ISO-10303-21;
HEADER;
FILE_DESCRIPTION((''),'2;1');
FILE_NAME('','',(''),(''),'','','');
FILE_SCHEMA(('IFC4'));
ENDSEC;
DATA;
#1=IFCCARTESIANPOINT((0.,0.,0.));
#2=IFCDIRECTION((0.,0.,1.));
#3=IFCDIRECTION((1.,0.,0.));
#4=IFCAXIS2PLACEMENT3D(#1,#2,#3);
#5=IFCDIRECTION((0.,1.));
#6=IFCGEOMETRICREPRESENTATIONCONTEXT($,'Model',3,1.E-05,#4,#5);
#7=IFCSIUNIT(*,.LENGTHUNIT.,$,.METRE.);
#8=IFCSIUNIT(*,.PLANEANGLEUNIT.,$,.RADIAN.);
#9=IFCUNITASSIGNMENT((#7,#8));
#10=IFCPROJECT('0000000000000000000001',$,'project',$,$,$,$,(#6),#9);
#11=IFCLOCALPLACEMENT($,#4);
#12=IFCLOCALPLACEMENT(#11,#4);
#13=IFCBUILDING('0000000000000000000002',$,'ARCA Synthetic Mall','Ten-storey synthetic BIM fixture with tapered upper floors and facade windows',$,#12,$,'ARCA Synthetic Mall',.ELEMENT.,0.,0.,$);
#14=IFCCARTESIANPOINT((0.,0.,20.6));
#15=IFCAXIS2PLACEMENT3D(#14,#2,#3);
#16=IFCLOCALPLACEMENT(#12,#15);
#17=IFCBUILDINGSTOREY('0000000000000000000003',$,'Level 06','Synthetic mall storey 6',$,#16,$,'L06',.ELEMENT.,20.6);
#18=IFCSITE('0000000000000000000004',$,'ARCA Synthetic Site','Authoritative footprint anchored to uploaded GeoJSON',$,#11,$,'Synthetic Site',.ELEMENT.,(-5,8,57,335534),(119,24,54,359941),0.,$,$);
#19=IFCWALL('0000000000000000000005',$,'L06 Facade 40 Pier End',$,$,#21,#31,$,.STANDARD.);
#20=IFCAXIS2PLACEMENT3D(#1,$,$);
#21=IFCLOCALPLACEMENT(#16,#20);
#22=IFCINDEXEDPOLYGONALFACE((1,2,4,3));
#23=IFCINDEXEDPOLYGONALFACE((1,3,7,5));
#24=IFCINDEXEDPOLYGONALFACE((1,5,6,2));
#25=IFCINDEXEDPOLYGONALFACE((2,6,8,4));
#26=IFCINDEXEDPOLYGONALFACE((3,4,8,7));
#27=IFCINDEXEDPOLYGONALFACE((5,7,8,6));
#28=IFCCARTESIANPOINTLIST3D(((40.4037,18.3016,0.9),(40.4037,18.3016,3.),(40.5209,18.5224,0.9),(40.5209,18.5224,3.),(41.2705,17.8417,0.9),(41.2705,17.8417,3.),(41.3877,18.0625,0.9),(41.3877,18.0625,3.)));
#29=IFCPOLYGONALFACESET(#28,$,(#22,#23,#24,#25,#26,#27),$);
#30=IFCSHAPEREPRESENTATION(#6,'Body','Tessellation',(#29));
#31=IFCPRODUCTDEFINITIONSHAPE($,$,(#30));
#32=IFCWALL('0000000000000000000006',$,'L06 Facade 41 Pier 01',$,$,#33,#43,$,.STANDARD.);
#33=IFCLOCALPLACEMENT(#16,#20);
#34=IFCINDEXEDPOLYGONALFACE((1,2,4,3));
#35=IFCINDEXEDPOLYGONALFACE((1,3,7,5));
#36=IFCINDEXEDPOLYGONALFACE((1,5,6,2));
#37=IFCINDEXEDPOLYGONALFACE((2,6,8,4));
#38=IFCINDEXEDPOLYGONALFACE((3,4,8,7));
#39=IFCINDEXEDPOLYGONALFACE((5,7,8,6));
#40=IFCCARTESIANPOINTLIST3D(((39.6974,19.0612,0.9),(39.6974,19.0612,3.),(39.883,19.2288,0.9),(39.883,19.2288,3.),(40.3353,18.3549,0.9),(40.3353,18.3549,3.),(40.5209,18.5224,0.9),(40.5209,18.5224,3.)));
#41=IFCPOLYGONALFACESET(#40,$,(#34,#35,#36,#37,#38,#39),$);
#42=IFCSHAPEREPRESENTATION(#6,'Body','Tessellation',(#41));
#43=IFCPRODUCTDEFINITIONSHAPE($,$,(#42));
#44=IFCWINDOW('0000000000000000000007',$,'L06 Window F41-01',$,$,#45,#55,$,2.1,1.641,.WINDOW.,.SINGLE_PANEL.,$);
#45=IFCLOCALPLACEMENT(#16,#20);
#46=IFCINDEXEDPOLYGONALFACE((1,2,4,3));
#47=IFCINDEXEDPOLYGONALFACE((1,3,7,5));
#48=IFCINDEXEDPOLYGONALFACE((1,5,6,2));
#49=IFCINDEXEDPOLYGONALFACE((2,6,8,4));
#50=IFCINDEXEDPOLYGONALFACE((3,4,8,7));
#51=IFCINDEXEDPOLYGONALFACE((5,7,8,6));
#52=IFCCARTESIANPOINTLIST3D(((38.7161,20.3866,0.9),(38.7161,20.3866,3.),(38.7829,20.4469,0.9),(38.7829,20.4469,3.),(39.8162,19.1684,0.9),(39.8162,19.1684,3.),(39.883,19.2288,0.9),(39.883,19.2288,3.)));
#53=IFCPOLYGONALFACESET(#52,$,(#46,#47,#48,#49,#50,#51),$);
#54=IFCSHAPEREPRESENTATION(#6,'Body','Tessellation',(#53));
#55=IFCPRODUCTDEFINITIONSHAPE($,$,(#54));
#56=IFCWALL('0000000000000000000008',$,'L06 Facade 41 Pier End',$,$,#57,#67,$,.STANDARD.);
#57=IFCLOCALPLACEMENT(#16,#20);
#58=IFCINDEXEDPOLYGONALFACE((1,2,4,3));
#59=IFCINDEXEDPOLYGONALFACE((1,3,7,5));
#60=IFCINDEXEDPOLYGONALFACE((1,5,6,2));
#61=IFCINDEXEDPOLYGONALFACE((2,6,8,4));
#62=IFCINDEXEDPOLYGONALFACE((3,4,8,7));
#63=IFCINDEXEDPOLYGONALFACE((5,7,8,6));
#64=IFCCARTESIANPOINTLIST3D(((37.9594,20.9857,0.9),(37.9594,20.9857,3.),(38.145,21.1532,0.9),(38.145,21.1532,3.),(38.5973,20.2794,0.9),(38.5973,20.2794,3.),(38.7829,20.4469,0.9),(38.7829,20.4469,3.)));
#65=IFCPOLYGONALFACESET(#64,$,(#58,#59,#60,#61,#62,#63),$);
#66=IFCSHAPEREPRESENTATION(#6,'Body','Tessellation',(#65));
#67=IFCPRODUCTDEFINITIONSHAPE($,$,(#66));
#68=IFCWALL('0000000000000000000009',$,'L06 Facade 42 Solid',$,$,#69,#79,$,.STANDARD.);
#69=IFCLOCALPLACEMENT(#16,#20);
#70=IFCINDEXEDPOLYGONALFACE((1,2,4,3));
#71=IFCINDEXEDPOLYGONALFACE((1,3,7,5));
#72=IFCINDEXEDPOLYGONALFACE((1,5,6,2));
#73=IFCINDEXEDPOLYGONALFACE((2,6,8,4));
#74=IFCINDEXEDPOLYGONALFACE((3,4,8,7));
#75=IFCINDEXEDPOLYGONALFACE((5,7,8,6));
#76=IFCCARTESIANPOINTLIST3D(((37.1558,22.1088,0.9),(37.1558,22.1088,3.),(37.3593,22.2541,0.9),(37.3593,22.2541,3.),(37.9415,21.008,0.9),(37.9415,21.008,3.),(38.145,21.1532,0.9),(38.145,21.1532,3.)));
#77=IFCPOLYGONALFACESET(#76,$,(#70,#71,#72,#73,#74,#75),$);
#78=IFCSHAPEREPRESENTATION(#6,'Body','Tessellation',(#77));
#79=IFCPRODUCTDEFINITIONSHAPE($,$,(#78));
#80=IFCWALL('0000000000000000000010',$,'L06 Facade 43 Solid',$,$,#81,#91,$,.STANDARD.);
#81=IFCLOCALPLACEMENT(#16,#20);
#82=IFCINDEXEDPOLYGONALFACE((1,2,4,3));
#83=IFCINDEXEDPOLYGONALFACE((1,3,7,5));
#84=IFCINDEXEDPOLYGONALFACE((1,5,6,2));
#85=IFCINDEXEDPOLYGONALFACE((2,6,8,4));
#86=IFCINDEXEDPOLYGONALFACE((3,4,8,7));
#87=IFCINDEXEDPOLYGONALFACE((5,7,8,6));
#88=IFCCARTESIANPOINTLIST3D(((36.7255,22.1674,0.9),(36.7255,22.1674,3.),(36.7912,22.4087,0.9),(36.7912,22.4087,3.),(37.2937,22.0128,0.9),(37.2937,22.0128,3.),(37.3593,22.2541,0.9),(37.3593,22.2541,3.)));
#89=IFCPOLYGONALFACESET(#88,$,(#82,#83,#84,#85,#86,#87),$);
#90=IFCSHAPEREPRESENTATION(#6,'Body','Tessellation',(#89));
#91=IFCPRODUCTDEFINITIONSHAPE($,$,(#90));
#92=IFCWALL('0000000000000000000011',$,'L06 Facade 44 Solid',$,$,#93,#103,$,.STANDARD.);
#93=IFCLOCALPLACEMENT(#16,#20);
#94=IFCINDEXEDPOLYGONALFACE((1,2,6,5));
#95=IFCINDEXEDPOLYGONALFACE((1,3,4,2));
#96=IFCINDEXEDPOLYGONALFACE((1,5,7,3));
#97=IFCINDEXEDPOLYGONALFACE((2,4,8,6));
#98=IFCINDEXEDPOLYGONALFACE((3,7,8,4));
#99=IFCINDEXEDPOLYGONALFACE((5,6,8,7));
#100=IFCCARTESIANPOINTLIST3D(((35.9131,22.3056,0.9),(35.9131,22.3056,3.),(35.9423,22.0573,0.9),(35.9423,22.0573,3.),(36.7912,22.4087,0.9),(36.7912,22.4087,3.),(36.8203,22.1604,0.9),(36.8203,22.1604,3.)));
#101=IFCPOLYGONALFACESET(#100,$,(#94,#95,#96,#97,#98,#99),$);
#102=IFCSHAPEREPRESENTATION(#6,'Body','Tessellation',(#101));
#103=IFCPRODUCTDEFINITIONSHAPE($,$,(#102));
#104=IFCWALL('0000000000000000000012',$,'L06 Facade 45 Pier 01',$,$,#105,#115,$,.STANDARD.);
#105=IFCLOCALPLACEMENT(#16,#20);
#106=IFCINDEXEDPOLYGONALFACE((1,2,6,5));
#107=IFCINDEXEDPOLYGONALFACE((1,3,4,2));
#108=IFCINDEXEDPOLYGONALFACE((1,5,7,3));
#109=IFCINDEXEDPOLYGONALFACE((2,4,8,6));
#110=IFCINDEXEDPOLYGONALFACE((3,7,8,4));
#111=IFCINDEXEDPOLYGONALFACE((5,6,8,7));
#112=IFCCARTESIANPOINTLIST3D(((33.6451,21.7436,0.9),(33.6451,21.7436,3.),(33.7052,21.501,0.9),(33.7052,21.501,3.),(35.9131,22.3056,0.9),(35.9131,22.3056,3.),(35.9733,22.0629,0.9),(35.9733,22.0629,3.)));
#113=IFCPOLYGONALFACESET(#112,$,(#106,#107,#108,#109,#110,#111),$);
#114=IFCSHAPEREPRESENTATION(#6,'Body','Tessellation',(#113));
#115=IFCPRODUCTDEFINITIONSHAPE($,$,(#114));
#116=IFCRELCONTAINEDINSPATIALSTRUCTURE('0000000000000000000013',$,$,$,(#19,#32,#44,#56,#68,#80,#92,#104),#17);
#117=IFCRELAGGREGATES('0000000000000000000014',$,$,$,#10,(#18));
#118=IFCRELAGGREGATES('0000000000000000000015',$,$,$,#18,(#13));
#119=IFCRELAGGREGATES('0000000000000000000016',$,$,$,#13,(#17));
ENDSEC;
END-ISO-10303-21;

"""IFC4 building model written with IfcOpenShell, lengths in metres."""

from ifc_helpers import new_model, si_unit, direction, frame, origin_with_axes, place, context, project, spatial, polyline, outline, extrude, element, save


model = new_model("IFC4")

# Units and contexts
model_context = context("Model", 3, precision=1e-05, world=origin_with_axes(), true_north=direction((0.0, 1.0)))
ifc_project = project(units=[si_unit("LENGTHUNIT", "METRE"), si_unit("PLANEANGLEUNIT", "RADIAN")], contexts=[model_context])

# Site, building, storey
site_placement = place(None, origin_with_axes())
site = spatial("IfcSite", under=ifc_project, at=site_placement, Name="ARCA Synthetic Site", Description="Authoritative footprint anchored to uploaded GeoJSON", LongName="Synthetic Site", CompositionType="ELEMENT", RefLatitude=(-5, 8, 57, 335534), RefLongitude=(119, 24, 54, 359941), RefElevation=0.0)
building_placement = place(site_placement, origin_with_axes())
building = spatial("IfcBuilding", under=site, at=building_placement, Name="ARCA Synthetic Mall", Description="Ten-storey synthetic BIM fixture with tapered upper floors and facade windows", LongName="ARCA Synthetic Mall", CompositionType="ELEMENT", ElevationOfRefHeight=0.0, ElevationOfTerrain=0.0)
storey_placement = place(building_placement, frame((0.0, 0.0, 20.6), z_axis=(0.0, 0.0, 1.0), x_axis=(1.0, 0.0, 0.0)))
storey = spatial("IfcBuildingStorey", under=building, at=storey_placement, Name="Level 06", Description="Synthetic mall storey 6", LongName="L06", CompositionType="ELEMENT", Elevation=20.6)

# Walls
wall_1_placement = place(storey_placement, frame((0.0, 0.0, 0.9), z_axis=(0.0, 0.0, 1.0), x_axis=(1.0, 0.0, 0.0)))
element("IfcWall", 1, at=wall_1_placement, inside=storey, Name="L06 Facade 40 Pier End", PredefinedType="STANDARD", context=model_context, shape_type="SweptSolid", body=[
    extrude(outline(polyline([(41.3877, 18.0625), (40.5209, 18.5224), (40.4037, 18.3016), (41.2705, 17.8417), (41.3877, 18.0625)])), origin_with_axes(), (0.0, 0.0, 1.0), 2.1),
])
wall_2_placement = place(storey_placement, frame((0.0, 0.0, 0.9), z_axis=(0.0, 0.0, 1.0), x_axis=(1.0, 0.0, 0.0)))
element("IfcWall", 2, at=wall_2_placement, inside=storey, Name="L06 Facade 41 Pier 01", PredefinedType="STANDARD", context=model_context, shape_type="SweptSolid", body=[
    extrude(outline(polyline([(40.5209, 18.5224), (39.883, 19.2288), (39.6974, 19.0612), (40.3353, 18.3549), (40.5209, 18.5224)])), origin_with_axes(), (0.0, 0.0, 1.0), 2.1),
])

# Window
window_1_placement = place(storey_placement, frame((0.0, 0.0, 0.9), z_axis=(0.0, 0.0, 1.0), x_axis=(1.0, 0.0, 0.0)))
element("IfcWindow", 3, at=window_1_placement, inside=storey, Name="L06 Window F41-01", OverallHeight=2.1, OverallWidth=1.641, PartitioningType="SINGLE_PANEL", PredefinedType="WINDOW", context=model_context, shape_type="SweptSolid", body=[
    extrude(outline(polyline([(39.883, 19.2288), (38.7829, 20.4469), (38.7161, 20.3866), (39.8162, 19.1684), (39.883, 19.2288)])), origin_with_axes(), (0.0, 0.0, 1.0), 2.1),
])

# Walls
wall_3_placement = place(storey_placement, frame((0.0, 0.0, 0.9), z_axis=(0.0, 0.0, 1.0), x_axis=(1.0, 0.0, 0.0)))
element("IfcWall", 4, at=wall_3_placement, inside=storey, Name="L06 Facade 41 Pier End", PredefinedType="STANDARD", context=model_context, shape_type="SweptSolid", body=[
    extrude(outline(polyline([(38.7829, 20.4469), (38.145, 21.1532), (37.9594, 20.9857), (38.5973, 20.2794), (38.7829, 20.4469)])), origin_with_axes(), (0.0, 0.0, 1.0), 2.1),
])
wall_4_placement = place(storey_placement, frame((0.0, 0.0, 0.9), z_axis=(0.0, 0.0, 1.0), x_axis=(1.0, 0.0, 0.0)))
element("IfcWall", 5, at=wall_4_placement, inside=storey, Name="L06 Facade 42 Solid", PredefinedType="STANDARD", context=model_context, shape_type="SweptSolid", body=[
    extrude(outline(polyline([(38.145, 21.1532), (37.3593, 22.2541), (37.1558, 22.1088), (37.9415, 21.008), (38.145, 21.1532)])), origin_with_axes(), (0.0, 0.0, 1.0), 2.1),
])
wall_5_placement = place(storey_placement, frame((0.0, 0.0, 0.9), z_axis=(0.0, 0.0, 1.0), x_axis=(1.0, 0.0, 0.0)))
element("IfcWall", 6, at=wall_5_placement, inside=storey, Name="L06 Facade 43 Solid", PredefinedType="STANDARD", context=model_context, shape_type="SweptSolid", body=[
    extrude(outline(polyline([(37.3593, 22.2541), (36.7912, 22.4087), (36.7255, 22.1674), (37.2937, 22.0128), (37.3593, 22.2541)])), origin_with_axes(), (0.0, 0.0, 1.0), 2.1),
])
wall_6_placement = place(storey_placement, frame((0.0, 0.0, 0.9), z_axis=(0.0, 0.0, 1.0), x_axis=(1.0, 0.0, 0.0)))
element("IfcWall", 7, at=wall_6_placement, inside=storey, Name="L06 Facade 44 Solid", PredefinedType="STANDARD", context=model_context, shape_type="SweptSolid", body=[
    extrude(outline(polyline([(36.7912, 22.4087), (35.9131, 22.3056), (35.9423, 22.0573), (36.8203, 22.1604), (36.7912, 22.4087)])), origin_with_axes(), (0.0, 0.0, 1.0), 2.1),
])
wall_7_placement = place(storey_placement, frame((0.0, 0.0, 0.9), z_axis=(0.0, 0.0, 1.0), x_axis=(1.0, 0.0, 0.0)))
element("IfcWall", 8, at=wall_7_placement, inside=storey, Name="L06 Facade 45 Pier 01", PredefinedType="STANDARD", context=model_context, shape_type="SweptSolid", body=[
    extrude(outline(polyline([(35.9131, 22.3056), (33.6451, 21.7436), (33.7052, 21.501), (35.9733, 22.0629), (35.9131, 22.3056)])), origin_with_axes(), (0.0, 0.0, 1.0), 2.1),
])

save(model, "model.ifc")
